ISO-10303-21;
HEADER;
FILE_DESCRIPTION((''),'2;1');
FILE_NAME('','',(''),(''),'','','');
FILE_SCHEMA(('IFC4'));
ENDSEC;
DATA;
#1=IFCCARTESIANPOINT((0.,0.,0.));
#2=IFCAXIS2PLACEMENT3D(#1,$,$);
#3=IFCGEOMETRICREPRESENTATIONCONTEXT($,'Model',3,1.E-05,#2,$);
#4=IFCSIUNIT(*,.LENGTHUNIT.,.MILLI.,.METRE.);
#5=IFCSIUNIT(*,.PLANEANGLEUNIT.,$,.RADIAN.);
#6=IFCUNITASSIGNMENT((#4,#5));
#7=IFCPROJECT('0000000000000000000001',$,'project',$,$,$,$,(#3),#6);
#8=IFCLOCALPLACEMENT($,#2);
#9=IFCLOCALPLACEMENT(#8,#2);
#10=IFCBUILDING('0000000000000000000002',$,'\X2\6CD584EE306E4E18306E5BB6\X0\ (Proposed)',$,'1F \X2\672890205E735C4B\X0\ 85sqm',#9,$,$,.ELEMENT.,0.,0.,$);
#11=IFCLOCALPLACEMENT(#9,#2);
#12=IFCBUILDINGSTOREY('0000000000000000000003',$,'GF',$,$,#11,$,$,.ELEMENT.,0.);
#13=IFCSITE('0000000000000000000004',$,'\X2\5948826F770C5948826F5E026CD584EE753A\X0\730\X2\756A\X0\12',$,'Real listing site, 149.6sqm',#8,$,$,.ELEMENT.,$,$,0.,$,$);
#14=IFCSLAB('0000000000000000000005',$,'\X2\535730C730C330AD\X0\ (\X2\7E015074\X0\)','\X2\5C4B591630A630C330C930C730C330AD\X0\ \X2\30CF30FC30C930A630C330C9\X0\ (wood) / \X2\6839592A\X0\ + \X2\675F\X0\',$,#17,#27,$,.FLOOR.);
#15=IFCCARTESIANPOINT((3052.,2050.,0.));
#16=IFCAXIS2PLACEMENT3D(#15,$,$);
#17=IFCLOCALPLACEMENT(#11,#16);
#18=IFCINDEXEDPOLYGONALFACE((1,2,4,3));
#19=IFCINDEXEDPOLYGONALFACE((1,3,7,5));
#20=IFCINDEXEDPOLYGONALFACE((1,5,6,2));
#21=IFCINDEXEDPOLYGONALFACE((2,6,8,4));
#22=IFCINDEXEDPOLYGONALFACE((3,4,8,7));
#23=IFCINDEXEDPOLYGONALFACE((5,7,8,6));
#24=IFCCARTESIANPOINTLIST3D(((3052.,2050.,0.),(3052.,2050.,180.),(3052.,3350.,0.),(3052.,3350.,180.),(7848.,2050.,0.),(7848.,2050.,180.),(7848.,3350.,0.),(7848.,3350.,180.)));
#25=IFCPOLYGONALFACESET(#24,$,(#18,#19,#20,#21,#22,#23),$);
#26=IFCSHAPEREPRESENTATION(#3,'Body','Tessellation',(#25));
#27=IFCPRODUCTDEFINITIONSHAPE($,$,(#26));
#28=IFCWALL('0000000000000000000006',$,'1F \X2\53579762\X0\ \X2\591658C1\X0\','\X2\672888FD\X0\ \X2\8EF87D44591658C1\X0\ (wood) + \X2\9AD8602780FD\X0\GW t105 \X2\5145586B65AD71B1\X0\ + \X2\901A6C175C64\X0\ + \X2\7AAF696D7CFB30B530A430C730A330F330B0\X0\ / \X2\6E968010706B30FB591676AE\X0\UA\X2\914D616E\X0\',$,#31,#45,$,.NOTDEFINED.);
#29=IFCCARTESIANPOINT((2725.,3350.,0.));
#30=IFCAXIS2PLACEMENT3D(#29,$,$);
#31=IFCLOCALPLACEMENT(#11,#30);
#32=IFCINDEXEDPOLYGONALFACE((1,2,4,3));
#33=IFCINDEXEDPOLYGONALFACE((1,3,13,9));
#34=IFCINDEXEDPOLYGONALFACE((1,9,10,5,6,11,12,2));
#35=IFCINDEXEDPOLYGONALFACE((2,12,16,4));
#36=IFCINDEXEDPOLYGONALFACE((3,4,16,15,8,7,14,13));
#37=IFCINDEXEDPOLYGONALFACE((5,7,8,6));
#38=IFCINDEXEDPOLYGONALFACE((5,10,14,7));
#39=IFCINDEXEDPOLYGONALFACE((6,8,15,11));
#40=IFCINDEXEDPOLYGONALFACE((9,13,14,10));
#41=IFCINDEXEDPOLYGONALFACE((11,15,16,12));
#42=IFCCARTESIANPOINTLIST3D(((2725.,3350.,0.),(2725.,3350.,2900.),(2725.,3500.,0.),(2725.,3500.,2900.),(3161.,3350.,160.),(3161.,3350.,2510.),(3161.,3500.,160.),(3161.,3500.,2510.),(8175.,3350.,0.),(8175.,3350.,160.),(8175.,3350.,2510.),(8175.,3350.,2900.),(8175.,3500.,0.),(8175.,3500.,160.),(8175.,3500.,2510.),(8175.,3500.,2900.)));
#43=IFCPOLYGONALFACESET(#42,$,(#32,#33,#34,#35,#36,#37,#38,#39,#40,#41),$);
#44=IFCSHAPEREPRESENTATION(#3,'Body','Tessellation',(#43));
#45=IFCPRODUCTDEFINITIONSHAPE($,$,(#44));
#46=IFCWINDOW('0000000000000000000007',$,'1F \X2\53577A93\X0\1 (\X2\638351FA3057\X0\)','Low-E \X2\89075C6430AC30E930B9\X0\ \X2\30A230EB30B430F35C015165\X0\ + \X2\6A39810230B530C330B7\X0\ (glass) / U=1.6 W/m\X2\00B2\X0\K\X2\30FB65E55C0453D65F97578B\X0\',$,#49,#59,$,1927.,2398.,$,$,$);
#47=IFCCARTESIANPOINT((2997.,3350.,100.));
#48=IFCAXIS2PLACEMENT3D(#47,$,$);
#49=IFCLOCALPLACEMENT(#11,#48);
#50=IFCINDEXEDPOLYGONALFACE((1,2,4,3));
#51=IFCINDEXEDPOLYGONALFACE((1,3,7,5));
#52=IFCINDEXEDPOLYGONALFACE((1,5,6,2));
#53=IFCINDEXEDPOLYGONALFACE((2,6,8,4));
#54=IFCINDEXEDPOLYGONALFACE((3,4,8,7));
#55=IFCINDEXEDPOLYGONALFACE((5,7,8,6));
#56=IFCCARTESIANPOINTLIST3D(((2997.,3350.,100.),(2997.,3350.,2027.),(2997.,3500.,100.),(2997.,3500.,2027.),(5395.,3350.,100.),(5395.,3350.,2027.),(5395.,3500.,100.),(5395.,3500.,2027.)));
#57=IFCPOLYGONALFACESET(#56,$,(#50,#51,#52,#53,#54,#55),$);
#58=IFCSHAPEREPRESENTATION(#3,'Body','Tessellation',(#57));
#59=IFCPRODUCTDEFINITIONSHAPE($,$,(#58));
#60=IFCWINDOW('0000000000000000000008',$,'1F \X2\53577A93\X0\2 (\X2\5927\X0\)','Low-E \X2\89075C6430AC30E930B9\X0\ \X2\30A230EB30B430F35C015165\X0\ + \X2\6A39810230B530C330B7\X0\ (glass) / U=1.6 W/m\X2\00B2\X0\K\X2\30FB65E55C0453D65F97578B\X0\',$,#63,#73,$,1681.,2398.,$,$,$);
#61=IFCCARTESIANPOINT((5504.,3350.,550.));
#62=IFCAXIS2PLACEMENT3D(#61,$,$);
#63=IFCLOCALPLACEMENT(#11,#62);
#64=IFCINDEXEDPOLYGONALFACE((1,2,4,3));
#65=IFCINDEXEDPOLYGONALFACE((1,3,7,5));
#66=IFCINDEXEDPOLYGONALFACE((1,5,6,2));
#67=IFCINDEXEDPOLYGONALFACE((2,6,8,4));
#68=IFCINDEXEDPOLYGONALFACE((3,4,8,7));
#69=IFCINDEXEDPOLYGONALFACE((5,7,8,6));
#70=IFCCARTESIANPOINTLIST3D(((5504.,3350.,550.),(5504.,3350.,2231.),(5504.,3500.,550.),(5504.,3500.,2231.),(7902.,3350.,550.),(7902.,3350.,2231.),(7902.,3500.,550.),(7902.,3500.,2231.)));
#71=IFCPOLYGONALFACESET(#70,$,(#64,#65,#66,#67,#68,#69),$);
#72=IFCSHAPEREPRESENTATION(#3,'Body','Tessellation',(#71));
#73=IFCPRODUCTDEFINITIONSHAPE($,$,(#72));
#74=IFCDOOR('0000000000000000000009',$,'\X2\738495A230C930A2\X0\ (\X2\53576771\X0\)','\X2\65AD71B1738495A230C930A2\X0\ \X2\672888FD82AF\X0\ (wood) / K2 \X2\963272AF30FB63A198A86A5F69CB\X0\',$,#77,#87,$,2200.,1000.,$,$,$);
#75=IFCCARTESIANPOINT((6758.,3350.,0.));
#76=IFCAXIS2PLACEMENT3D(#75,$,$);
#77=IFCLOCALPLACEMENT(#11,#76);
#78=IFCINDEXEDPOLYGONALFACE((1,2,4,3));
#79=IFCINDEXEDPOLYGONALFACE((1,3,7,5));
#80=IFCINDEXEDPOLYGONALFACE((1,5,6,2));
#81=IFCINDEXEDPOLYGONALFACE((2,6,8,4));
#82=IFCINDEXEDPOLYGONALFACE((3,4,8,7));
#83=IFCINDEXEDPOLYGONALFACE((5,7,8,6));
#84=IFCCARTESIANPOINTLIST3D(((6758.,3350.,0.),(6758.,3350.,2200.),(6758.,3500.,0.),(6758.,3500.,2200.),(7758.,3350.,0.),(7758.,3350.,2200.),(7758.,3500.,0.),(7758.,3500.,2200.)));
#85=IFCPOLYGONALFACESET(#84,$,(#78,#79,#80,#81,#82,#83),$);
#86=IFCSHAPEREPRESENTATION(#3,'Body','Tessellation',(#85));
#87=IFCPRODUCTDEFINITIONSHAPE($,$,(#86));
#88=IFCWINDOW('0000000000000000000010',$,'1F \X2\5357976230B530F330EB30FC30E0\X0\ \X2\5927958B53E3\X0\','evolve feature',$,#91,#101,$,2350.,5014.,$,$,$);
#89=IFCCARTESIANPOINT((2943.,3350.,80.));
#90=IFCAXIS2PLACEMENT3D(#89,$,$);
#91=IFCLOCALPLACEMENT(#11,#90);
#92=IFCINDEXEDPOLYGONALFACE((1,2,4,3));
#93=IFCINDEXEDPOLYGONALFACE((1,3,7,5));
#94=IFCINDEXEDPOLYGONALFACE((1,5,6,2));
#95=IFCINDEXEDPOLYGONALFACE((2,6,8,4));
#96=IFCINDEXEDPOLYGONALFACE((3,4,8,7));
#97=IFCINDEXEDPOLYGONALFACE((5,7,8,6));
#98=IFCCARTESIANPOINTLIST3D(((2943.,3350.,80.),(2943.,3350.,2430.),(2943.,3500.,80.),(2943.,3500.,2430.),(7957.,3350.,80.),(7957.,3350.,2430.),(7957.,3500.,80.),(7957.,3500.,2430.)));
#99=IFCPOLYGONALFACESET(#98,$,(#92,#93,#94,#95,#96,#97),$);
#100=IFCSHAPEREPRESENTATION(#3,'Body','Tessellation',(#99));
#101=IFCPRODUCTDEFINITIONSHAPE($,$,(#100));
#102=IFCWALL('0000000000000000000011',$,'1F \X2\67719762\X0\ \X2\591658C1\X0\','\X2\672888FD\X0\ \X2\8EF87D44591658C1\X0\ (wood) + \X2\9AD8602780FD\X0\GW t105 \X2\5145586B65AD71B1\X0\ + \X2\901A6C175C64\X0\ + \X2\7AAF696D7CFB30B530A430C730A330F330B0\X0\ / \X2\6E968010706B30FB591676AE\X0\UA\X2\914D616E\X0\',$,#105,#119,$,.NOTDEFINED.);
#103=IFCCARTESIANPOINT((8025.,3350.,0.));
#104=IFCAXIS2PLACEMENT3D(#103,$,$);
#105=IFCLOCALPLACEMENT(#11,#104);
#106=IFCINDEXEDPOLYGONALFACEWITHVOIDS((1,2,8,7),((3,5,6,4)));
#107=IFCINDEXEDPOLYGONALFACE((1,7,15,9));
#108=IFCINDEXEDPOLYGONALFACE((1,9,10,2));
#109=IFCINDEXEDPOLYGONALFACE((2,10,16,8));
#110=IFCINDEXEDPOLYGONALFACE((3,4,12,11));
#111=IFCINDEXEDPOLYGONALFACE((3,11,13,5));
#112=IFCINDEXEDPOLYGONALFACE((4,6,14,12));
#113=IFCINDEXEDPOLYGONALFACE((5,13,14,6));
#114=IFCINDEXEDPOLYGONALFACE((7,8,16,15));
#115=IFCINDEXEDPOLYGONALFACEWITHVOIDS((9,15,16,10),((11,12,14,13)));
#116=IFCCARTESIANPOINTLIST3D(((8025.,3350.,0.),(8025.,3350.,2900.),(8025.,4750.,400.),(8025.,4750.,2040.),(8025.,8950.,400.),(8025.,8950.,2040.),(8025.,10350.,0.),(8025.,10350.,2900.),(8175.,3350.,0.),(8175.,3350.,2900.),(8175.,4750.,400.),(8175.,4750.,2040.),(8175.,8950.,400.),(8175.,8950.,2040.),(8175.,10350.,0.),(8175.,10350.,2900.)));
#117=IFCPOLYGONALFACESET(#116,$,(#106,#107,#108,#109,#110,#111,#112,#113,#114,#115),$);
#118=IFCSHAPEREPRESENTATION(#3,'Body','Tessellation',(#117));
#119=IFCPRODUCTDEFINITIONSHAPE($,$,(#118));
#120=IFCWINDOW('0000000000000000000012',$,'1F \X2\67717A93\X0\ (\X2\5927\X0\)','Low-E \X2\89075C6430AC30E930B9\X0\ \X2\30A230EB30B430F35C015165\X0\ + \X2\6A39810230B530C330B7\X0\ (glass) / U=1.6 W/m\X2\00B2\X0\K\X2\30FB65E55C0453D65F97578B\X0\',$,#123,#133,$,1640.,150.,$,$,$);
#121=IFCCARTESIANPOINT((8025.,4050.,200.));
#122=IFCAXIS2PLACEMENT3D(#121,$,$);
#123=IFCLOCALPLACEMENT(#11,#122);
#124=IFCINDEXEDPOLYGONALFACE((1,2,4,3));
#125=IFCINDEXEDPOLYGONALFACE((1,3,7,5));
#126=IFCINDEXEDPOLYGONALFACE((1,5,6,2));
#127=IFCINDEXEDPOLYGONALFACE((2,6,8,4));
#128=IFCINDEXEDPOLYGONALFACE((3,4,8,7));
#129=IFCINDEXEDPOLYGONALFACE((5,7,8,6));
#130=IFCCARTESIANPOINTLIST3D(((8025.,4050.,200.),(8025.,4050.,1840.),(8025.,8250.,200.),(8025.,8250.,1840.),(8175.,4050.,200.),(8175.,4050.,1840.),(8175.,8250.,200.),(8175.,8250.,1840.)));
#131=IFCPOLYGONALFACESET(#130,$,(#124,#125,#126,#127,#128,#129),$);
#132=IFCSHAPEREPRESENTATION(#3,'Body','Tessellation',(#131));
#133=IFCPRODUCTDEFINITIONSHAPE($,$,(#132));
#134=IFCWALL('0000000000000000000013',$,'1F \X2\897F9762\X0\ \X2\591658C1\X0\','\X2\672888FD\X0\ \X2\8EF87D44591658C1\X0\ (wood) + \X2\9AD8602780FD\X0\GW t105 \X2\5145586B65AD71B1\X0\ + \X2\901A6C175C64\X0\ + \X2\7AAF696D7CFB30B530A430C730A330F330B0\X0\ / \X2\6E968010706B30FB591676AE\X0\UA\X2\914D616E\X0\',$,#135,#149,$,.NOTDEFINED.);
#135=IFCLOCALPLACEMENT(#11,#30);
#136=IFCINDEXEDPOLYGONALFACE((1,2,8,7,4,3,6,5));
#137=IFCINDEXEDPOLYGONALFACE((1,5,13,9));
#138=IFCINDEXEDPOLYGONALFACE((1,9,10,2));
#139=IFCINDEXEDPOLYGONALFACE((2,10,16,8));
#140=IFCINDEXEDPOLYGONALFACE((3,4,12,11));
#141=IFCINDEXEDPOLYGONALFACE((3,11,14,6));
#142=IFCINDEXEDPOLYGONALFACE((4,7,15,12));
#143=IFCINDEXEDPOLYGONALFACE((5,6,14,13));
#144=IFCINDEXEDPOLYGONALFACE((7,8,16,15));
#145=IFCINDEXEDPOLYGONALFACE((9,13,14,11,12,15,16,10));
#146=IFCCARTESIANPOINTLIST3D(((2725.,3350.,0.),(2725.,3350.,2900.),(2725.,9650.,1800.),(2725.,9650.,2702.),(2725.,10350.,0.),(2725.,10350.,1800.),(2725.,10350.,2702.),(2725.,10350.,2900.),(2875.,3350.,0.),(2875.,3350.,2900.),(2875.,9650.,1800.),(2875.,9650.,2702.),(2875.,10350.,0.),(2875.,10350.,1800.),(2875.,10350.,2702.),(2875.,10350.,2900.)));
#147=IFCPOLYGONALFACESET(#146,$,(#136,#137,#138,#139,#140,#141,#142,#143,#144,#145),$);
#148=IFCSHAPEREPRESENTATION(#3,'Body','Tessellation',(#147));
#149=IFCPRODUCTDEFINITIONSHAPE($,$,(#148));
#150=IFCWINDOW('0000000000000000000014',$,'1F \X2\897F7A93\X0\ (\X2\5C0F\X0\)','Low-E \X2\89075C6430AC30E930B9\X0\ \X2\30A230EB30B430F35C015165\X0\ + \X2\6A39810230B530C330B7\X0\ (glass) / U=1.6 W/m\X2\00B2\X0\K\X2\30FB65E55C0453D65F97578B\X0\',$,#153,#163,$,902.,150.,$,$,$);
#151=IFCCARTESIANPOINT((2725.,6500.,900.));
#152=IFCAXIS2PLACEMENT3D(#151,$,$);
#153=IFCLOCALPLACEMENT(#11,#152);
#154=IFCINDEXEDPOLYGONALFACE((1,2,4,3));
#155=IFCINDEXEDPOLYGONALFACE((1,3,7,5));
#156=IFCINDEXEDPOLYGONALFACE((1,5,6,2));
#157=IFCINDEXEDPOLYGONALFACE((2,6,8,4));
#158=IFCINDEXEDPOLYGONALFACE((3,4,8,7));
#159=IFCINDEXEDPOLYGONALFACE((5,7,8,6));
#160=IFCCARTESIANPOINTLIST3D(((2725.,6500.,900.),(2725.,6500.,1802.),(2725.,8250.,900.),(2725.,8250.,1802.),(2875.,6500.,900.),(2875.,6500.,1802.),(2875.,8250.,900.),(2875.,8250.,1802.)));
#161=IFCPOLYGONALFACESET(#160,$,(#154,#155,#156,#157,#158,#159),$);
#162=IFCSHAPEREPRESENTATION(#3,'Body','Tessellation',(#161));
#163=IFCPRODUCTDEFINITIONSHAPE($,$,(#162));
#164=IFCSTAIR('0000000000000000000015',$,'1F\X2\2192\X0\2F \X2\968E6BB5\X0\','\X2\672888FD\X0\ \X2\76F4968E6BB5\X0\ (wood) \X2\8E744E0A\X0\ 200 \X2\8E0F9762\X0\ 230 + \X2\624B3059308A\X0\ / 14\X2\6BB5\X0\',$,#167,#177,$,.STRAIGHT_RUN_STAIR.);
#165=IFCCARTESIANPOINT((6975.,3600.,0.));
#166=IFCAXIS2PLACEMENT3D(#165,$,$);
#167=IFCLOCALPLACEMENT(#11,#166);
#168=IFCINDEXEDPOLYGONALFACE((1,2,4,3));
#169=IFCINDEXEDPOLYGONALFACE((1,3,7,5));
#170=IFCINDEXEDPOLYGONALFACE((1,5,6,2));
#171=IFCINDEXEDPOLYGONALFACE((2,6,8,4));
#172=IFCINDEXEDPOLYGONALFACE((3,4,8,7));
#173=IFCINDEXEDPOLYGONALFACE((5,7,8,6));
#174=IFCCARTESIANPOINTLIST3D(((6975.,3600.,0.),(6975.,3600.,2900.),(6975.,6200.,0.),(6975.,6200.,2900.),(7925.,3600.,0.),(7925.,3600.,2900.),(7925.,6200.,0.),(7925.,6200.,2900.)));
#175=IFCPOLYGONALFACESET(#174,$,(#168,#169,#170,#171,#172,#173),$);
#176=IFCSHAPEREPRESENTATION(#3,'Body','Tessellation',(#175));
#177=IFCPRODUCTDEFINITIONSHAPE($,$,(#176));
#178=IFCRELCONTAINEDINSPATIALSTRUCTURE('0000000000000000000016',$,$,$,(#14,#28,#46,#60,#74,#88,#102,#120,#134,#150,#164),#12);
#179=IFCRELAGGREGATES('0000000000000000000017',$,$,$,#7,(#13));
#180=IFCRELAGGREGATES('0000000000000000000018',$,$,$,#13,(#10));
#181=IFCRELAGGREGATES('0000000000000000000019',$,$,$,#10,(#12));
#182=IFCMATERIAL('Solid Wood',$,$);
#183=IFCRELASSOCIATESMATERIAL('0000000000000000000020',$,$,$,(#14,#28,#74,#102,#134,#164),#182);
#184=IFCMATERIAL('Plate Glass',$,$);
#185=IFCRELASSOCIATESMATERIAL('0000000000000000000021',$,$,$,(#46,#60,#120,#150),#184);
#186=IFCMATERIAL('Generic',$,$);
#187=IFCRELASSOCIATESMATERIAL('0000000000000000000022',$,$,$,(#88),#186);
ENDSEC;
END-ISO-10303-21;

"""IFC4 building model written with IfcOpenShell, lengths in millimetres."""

from ifc_helpers import new_model, si_unit, frame, frame_2d, origin, place, context, project, spatial, rectangle, extrude, material, element, fill, save


model = new_model("IFC4")

# Units and contexts
model_context = context("Model", 3, precision=1e-05, world=origin())
ifc_project = project(units=[si_unit("LENGTHUNIT", "METRE", prefix="MILLI"), si_unit("PLANEANGLEUNIT", "RADIAN")], contexts=[model_context])

# Site, building, storey
site_placement = place(None, origin())
site = spatial("IfcSite", under=ifc_project, at=site_placement, Name="奈良県奈良市法蓮町730番12", ObjectType="Real listing site, 149.6sqm", CompositionType="ELEMENT", RefElevation=0.0)
building_placement = place(site_placement, origin())
building = spatial("IfcBuilding", under=site, at=building_placement, Name="法蓮の丘の家 (Proposed)", ObjectType="1F 木造平屋 85sqm", CompositionType="ELEMENT", ElevationOfRefHeight=0.0, ElevationOfTerrain=0.0)
storey_placement = place(building_placement, origin())
storey = spatial("IfcBuildingStorey", under=building, at=storey_placement, Name="GF", CompositionType="ELEMENT", Elevation=0.0)

# Slab
ifc_material_1 = material(Name="Solid Wood")
slab_1_placement = place(storey_placement, frame((3052.0, 2050.0, 0.0)))
element("IfcSlab", 1, at=slab_1_placement, inside=storey, material=ifc_material_1, Name="南デッキ (縁側)", Description="屋外ウッドデッキ ハードウッド (wood) / 根太 + 束", PredefinedType="FLOOR", context=model_context, shape_type="SweptSolid", body=[
    extrude(rectangle(XDim=4796.0, YDim=1300.0, at=frame_2d((2398.0, 650.0))), frame((3052.0, 2050.0, 0.0)), (0.0, 0.0, 1.0), 180.0),
])
ifc_material_2 = material(Name="Generic")

# Wall, openings, windows, door
wall_1_placement = place(storey_placement, frame((2725.0, 3350.0, 0.0)))
wall_1 = element("IfcWall", 2, at=wall_1_placement, inside=storey, material=ifc_material_1, Name="1F 南面 外壁", Description="木製 軸組外壁 (wood) + 高性能GW t105 充填断熱 + 通気層 + 窯業系サイディング / 準耐火・外皮UA配慮", PredefinedType="NOTDEFINED", context=model_context, shape_type="SweptSolid", body=[
    extrude(rectangle(XDim=5450.0, YDim=150.0, at=frame_2d((2725.0, 75.0))), frame((2725.0, 3350.0, 0.0)), (0.0, 0.0, 1.0), 2900.0),
])
opening_1_placement = place(storey_placement, frame((2997.0, 3350.0, 100.0)))
opening_1 = element("IfcOpeningElement", 3, at=opening_1_placement, cuts=wall_1, PredefinedType="NOTDEFINED", context=model_context, shape_type="SweptSolid", body=[
    extrude(rectangle(XDim=2398.0, YDim=150.0, at=frame_2d((1199.0, 75.0))), frame((2997.0, 3350.0, 100.0)), (0.0, 0.0, 1.0), 1927.0),
])
opening_2_placement = place(storey_placement, frame((5504.0, 3350.0, 550.0)))
opening_2 = element("IfcOpeningElement", 4, at=opening_2_placement, cuts=wall_1, PredefinedType="NOTDEFINED", context=model_context, shape_type="SweptSolid", body=[
    extrude(rectangle(XDim=2398.0, YDim=150.0, at=frame_2d((1199.0, 75.0))), frame((5504.0, 3350.0, 550.0)), (0.0, 0.0, 1.0), 1681.0),
])
opening_3_placement = place(storey_placement, frame((6758.0, 3350.0, 0.0)))
opening_3 = element("IfcOpeningElement", 5, at=opening_3_placement, cuts=wall_1, PredefinedType="NOTDEFINED", context=model_context, shape_type="SweptSolid", body=[
    extrude(rectangle(XDim=1000.0, YDim=150.0, at=frame_2d((500.0, 75.0))), frame((6758.0, 3350.0, 0.0)), (0.0, 0.0, 1.0), 2200.0),
])
opening_4_placement = place(storey_placement, frame((2943.0, 3350.0, 80.0)))
opening_4 = element("IfcOpeningElement", 6, at=opening_4_placement, cuts=wall_1, PredefinedType="NOTDEFINED", context=model_context, shape_type="SweptSolid", body=[
    extrude(rectangle(XDim=5014.0, YDim=150.0, at=frame_2d((2507.0, 75.0))), frame((2943.0, 3350.0, 80.0)), (0.0, 0.0, 1.0), 2350.0),
])
ifc_material_3 = material(Name="Plate Glass")
window_1_placement = place(storey_placement, frame((2997.0, 3350.0, 100.0)))
window_1 = element("IfcWindow", 7, at=window_1_placement, inside=storey, material=ifc_material_3, Name="1F 南窓1 (掃出し)", Description="Low-E 複層ガラス アルゴン封入 + 樹脂サッシ (glass) / U=1.6 W/m²K・日射取得型", OverallHeight=1927.0, OverallWidth=2398.0, context=model_context, shape_type="SweptSolid", body=[
    extrude(rectangle(XDim=2398.0, YDim=150.0, at=frame_2d((1199.0, 75.0))), frame((2997.0, 3350.0, 100.0)), (0.0, 0.0, 1.0), 1927.0),
])
fill(opening_1, window_1)
window_2_placement = place(storey_placement, frame((5504.0, 3350.0, 550.0)))
window_2 = element("IfcWindow", 8, at=window_2_placement, inside=storey, material=ifc_material_3, Name="1F 南窓2 (大)", Description="Low-E 複層ガラス アルゴン封入 + 樹脂サッシ (glass) / U=1.6 W/m²K・日射取得型", OverallHeight=1681.0, OverallWidth=2398.0, context=model_context, shape_type="SweptSolid", body=[
    extrude(rectangle(XDim=2398.0, YDim=150.0, at=frame_2d((1199.0, 75.0))), frame((5504.0, 3350.0, 550.0)), (0.0, 0.0, 1.0), 1681.0),
])
fill(opening_2, window_2)
door_placement = place(storey_placement, frame((6758.0, 3350.0, 0.0)))
door = element("IfcDoor", 9, at=door_placement, inside=storey, material=ifc_material_1, Name="玄関ドア (南東)", Description="断熱玄関ドア 木製芯 (wood) / K2 防犯・採風機構", OverallHeight=2200.0, OverallWidth=1000.0, context=model_context, shape_type="SweptSolid", body=[
    extrude(rectangle(XDim=1000.0, YDim=150.0, at=frame_2d((500.0, 75.0))), frame((6758.0, 3350.0, 0.0)), (0.0, 0.0, 1.0), 2200.0),
])
fill(opening_3, door)
window_3_placement = place(storey_placement, frame((2943.0, 3350.0, 80.0)))
window_3 = element("IfcWindow", 10, at=window_3_placement, inside=storey, material=ifc_material_2, Name="1F 南面サンルーム 大開口", Description="evolve feature", OverallHeight=2350.0, OverallWidth=5014.0, context=model_context, shape_type="SweptSolid", body=[
    extrude(rectangle(XDim=5014.0, YDim=150.0, at=frame_2d((2507.0, 75.0))), frame((2943.0, 3350.0, 80.0)), (0.0, 0.0, 1.0), 2350.0),
])
fill(opening_4, window_3)

# Walls, openings, windows
wall_2_placement = place(storey_placement, frame((8025.0, 3350.0, 0.0)))
wall_2 = element("IfcWall", 11, at=wall_2_placement, inside=storey, material=ifc_material_1, Name="1F 東面 外壁", Description="木製 軸組外壁 (wood) + 高性能GW t105 充填断熱 + 通気層 + 窯業系サイディング / 準耐火・外皮UA配慮", PredefinedType="NOTDEFINED", context=model_context, shape_type="SweptSolid", body=[
    extrude(rectangle(XDim=150.0, YDim=7000.0, at=frame_2d((75.0, 3500.0))), frame((8025.0, 3350.0, 0.0)), (0.0, 0.0, 1.0), 2900.0),
])
opening_5_placement = place(storey_placement, frame((8025.0, 4050.0, 200.0)))
opening_5 = element("IfcOpeningElement", 12, at=opening_5_placement, cuts=wall_2, PredefinedType="NOTDEFINED", context=model_context, shape_type="SweptSolid", body=[
    extrude(rectangle(XDim=150.0, YDim=4200.0, at=frame_2d((75.0, 2100.0))), frame((8025.0, 4050.0, 200.0)), (0.0, 0.0, 1.0), 1640.0),
])
window_4_placement = place(storey_placement, frame((8025.0, 4050.0, 200.0)))
window_4 = element("IfcWindow", 13, at=window_4_placement, inside=storey, material=ifc_material_3, Name="1F 東窓 (大)", Description="Low-E 複層ガラス アルゴン封入 + 樹脂サッシ (glass) / U=1.6 W/m²K・日射取得型", OverallHeight=1640.0, OverallWidth=150.0, context=model_context, shape_type="SweptSolid", body=[
    extrude(rectangle(XDim=150.0, YDim=4200.0, at=frame_2d((75.0, 2100.0))), frame((8025.0, 4050.0, 200.0)), (0.0, 0.0, 1.0), 1640.0),
])
fill(opening_5, window_4)
wall_3_placement = place(storey_placement, frame((2725.0, 3350.0, 0.0)))
wall_3 = element("IfcWall", 14, at=wall_3_placement, inside=storey, material=ifc_material_1, Name="1F 西面 外壁", Description="木製 軸組外壁 (wood) + 高性能GW t105 充填断熱 + 通気層 + 窯業系サイディング / 準耐火・外皮UA配慮", PredefinedType="NOTDEFINED", context=model_context, shape_type="SweptSolid", body=[
    extrude(rectangle(XDim=150.0, YDim=7000.0, at=frame_2d((75.0, 3500.0))), frame((2725.0, 3350.0, 0.0)), (0.0, 0.0, 1.0), 2900.0),
])
opening_6_placement = place(storey_placement, frame((2725.0, 6500.0, 900.0)))
opening_6 = element("IfcOpeningElement", 15, at=opening_6_placement, cuts=wall_3, PredefinedType="NOTDEFINED", context=model_context, shape_type="SweptSolid", body=[
    extrude(rectangle(XDim=150.0, YDim=1750.0, at=frame_2d((75.0, 875.0))), frame((2725.0, 6500.0, 900.0)), (0.0, 0.0, 1.0), 902.0),
])
window_5_placement = place(storey_placement, frame((2725.0, 6500.0, 900.0)))
window_5 = element("IfcWindow", 16, at=window_5_placement, inside=storey, material=ifc_material_3, Name="1F 西窓 (小)", Description="Low-E 複層ガラス アルゴン封入 + 樹脂サッシ (glass) / U=1.6 W/m²K・日射取得型", OverallHeight=902.0, OverallWidth=150.0, context=model_context, shape_type="SweptSolid", body=[
    extrude(rectangle(XDim=150.0, YDim=1750.0, at=frame_2d((75.0, 875.0))), frame((2725.0, 6500.0, 900.0)), (0.0, 0.0, 1.0), 902.0),
])
fill(opening_6, window_5)

# Stair
stair_placement = place(storey_placement, frame((6975.0, 3600.0, 0.0)))
element("IfcStair", 17, at=stair_placement, inside=storey, material=ifc_material_1, Name="1F→2F 階段", Description="木製 直階段 (wood) 蹴上 200 踏面 230 + 手すり / 14段", PredefinedType="STRAIGHT_RUN_STAIR", context=model_context, shape_type="SweptSolid", body=[
    extrude(rectangle(XDim=950.0, YDim=2600.0, at=frame_2d((475.0, 1300.0))), frame((6975.0, 3600.0, 0.0)), (0.0, 0.0, 1.0), 2900.0),
])

save(model, "model.ifc")
